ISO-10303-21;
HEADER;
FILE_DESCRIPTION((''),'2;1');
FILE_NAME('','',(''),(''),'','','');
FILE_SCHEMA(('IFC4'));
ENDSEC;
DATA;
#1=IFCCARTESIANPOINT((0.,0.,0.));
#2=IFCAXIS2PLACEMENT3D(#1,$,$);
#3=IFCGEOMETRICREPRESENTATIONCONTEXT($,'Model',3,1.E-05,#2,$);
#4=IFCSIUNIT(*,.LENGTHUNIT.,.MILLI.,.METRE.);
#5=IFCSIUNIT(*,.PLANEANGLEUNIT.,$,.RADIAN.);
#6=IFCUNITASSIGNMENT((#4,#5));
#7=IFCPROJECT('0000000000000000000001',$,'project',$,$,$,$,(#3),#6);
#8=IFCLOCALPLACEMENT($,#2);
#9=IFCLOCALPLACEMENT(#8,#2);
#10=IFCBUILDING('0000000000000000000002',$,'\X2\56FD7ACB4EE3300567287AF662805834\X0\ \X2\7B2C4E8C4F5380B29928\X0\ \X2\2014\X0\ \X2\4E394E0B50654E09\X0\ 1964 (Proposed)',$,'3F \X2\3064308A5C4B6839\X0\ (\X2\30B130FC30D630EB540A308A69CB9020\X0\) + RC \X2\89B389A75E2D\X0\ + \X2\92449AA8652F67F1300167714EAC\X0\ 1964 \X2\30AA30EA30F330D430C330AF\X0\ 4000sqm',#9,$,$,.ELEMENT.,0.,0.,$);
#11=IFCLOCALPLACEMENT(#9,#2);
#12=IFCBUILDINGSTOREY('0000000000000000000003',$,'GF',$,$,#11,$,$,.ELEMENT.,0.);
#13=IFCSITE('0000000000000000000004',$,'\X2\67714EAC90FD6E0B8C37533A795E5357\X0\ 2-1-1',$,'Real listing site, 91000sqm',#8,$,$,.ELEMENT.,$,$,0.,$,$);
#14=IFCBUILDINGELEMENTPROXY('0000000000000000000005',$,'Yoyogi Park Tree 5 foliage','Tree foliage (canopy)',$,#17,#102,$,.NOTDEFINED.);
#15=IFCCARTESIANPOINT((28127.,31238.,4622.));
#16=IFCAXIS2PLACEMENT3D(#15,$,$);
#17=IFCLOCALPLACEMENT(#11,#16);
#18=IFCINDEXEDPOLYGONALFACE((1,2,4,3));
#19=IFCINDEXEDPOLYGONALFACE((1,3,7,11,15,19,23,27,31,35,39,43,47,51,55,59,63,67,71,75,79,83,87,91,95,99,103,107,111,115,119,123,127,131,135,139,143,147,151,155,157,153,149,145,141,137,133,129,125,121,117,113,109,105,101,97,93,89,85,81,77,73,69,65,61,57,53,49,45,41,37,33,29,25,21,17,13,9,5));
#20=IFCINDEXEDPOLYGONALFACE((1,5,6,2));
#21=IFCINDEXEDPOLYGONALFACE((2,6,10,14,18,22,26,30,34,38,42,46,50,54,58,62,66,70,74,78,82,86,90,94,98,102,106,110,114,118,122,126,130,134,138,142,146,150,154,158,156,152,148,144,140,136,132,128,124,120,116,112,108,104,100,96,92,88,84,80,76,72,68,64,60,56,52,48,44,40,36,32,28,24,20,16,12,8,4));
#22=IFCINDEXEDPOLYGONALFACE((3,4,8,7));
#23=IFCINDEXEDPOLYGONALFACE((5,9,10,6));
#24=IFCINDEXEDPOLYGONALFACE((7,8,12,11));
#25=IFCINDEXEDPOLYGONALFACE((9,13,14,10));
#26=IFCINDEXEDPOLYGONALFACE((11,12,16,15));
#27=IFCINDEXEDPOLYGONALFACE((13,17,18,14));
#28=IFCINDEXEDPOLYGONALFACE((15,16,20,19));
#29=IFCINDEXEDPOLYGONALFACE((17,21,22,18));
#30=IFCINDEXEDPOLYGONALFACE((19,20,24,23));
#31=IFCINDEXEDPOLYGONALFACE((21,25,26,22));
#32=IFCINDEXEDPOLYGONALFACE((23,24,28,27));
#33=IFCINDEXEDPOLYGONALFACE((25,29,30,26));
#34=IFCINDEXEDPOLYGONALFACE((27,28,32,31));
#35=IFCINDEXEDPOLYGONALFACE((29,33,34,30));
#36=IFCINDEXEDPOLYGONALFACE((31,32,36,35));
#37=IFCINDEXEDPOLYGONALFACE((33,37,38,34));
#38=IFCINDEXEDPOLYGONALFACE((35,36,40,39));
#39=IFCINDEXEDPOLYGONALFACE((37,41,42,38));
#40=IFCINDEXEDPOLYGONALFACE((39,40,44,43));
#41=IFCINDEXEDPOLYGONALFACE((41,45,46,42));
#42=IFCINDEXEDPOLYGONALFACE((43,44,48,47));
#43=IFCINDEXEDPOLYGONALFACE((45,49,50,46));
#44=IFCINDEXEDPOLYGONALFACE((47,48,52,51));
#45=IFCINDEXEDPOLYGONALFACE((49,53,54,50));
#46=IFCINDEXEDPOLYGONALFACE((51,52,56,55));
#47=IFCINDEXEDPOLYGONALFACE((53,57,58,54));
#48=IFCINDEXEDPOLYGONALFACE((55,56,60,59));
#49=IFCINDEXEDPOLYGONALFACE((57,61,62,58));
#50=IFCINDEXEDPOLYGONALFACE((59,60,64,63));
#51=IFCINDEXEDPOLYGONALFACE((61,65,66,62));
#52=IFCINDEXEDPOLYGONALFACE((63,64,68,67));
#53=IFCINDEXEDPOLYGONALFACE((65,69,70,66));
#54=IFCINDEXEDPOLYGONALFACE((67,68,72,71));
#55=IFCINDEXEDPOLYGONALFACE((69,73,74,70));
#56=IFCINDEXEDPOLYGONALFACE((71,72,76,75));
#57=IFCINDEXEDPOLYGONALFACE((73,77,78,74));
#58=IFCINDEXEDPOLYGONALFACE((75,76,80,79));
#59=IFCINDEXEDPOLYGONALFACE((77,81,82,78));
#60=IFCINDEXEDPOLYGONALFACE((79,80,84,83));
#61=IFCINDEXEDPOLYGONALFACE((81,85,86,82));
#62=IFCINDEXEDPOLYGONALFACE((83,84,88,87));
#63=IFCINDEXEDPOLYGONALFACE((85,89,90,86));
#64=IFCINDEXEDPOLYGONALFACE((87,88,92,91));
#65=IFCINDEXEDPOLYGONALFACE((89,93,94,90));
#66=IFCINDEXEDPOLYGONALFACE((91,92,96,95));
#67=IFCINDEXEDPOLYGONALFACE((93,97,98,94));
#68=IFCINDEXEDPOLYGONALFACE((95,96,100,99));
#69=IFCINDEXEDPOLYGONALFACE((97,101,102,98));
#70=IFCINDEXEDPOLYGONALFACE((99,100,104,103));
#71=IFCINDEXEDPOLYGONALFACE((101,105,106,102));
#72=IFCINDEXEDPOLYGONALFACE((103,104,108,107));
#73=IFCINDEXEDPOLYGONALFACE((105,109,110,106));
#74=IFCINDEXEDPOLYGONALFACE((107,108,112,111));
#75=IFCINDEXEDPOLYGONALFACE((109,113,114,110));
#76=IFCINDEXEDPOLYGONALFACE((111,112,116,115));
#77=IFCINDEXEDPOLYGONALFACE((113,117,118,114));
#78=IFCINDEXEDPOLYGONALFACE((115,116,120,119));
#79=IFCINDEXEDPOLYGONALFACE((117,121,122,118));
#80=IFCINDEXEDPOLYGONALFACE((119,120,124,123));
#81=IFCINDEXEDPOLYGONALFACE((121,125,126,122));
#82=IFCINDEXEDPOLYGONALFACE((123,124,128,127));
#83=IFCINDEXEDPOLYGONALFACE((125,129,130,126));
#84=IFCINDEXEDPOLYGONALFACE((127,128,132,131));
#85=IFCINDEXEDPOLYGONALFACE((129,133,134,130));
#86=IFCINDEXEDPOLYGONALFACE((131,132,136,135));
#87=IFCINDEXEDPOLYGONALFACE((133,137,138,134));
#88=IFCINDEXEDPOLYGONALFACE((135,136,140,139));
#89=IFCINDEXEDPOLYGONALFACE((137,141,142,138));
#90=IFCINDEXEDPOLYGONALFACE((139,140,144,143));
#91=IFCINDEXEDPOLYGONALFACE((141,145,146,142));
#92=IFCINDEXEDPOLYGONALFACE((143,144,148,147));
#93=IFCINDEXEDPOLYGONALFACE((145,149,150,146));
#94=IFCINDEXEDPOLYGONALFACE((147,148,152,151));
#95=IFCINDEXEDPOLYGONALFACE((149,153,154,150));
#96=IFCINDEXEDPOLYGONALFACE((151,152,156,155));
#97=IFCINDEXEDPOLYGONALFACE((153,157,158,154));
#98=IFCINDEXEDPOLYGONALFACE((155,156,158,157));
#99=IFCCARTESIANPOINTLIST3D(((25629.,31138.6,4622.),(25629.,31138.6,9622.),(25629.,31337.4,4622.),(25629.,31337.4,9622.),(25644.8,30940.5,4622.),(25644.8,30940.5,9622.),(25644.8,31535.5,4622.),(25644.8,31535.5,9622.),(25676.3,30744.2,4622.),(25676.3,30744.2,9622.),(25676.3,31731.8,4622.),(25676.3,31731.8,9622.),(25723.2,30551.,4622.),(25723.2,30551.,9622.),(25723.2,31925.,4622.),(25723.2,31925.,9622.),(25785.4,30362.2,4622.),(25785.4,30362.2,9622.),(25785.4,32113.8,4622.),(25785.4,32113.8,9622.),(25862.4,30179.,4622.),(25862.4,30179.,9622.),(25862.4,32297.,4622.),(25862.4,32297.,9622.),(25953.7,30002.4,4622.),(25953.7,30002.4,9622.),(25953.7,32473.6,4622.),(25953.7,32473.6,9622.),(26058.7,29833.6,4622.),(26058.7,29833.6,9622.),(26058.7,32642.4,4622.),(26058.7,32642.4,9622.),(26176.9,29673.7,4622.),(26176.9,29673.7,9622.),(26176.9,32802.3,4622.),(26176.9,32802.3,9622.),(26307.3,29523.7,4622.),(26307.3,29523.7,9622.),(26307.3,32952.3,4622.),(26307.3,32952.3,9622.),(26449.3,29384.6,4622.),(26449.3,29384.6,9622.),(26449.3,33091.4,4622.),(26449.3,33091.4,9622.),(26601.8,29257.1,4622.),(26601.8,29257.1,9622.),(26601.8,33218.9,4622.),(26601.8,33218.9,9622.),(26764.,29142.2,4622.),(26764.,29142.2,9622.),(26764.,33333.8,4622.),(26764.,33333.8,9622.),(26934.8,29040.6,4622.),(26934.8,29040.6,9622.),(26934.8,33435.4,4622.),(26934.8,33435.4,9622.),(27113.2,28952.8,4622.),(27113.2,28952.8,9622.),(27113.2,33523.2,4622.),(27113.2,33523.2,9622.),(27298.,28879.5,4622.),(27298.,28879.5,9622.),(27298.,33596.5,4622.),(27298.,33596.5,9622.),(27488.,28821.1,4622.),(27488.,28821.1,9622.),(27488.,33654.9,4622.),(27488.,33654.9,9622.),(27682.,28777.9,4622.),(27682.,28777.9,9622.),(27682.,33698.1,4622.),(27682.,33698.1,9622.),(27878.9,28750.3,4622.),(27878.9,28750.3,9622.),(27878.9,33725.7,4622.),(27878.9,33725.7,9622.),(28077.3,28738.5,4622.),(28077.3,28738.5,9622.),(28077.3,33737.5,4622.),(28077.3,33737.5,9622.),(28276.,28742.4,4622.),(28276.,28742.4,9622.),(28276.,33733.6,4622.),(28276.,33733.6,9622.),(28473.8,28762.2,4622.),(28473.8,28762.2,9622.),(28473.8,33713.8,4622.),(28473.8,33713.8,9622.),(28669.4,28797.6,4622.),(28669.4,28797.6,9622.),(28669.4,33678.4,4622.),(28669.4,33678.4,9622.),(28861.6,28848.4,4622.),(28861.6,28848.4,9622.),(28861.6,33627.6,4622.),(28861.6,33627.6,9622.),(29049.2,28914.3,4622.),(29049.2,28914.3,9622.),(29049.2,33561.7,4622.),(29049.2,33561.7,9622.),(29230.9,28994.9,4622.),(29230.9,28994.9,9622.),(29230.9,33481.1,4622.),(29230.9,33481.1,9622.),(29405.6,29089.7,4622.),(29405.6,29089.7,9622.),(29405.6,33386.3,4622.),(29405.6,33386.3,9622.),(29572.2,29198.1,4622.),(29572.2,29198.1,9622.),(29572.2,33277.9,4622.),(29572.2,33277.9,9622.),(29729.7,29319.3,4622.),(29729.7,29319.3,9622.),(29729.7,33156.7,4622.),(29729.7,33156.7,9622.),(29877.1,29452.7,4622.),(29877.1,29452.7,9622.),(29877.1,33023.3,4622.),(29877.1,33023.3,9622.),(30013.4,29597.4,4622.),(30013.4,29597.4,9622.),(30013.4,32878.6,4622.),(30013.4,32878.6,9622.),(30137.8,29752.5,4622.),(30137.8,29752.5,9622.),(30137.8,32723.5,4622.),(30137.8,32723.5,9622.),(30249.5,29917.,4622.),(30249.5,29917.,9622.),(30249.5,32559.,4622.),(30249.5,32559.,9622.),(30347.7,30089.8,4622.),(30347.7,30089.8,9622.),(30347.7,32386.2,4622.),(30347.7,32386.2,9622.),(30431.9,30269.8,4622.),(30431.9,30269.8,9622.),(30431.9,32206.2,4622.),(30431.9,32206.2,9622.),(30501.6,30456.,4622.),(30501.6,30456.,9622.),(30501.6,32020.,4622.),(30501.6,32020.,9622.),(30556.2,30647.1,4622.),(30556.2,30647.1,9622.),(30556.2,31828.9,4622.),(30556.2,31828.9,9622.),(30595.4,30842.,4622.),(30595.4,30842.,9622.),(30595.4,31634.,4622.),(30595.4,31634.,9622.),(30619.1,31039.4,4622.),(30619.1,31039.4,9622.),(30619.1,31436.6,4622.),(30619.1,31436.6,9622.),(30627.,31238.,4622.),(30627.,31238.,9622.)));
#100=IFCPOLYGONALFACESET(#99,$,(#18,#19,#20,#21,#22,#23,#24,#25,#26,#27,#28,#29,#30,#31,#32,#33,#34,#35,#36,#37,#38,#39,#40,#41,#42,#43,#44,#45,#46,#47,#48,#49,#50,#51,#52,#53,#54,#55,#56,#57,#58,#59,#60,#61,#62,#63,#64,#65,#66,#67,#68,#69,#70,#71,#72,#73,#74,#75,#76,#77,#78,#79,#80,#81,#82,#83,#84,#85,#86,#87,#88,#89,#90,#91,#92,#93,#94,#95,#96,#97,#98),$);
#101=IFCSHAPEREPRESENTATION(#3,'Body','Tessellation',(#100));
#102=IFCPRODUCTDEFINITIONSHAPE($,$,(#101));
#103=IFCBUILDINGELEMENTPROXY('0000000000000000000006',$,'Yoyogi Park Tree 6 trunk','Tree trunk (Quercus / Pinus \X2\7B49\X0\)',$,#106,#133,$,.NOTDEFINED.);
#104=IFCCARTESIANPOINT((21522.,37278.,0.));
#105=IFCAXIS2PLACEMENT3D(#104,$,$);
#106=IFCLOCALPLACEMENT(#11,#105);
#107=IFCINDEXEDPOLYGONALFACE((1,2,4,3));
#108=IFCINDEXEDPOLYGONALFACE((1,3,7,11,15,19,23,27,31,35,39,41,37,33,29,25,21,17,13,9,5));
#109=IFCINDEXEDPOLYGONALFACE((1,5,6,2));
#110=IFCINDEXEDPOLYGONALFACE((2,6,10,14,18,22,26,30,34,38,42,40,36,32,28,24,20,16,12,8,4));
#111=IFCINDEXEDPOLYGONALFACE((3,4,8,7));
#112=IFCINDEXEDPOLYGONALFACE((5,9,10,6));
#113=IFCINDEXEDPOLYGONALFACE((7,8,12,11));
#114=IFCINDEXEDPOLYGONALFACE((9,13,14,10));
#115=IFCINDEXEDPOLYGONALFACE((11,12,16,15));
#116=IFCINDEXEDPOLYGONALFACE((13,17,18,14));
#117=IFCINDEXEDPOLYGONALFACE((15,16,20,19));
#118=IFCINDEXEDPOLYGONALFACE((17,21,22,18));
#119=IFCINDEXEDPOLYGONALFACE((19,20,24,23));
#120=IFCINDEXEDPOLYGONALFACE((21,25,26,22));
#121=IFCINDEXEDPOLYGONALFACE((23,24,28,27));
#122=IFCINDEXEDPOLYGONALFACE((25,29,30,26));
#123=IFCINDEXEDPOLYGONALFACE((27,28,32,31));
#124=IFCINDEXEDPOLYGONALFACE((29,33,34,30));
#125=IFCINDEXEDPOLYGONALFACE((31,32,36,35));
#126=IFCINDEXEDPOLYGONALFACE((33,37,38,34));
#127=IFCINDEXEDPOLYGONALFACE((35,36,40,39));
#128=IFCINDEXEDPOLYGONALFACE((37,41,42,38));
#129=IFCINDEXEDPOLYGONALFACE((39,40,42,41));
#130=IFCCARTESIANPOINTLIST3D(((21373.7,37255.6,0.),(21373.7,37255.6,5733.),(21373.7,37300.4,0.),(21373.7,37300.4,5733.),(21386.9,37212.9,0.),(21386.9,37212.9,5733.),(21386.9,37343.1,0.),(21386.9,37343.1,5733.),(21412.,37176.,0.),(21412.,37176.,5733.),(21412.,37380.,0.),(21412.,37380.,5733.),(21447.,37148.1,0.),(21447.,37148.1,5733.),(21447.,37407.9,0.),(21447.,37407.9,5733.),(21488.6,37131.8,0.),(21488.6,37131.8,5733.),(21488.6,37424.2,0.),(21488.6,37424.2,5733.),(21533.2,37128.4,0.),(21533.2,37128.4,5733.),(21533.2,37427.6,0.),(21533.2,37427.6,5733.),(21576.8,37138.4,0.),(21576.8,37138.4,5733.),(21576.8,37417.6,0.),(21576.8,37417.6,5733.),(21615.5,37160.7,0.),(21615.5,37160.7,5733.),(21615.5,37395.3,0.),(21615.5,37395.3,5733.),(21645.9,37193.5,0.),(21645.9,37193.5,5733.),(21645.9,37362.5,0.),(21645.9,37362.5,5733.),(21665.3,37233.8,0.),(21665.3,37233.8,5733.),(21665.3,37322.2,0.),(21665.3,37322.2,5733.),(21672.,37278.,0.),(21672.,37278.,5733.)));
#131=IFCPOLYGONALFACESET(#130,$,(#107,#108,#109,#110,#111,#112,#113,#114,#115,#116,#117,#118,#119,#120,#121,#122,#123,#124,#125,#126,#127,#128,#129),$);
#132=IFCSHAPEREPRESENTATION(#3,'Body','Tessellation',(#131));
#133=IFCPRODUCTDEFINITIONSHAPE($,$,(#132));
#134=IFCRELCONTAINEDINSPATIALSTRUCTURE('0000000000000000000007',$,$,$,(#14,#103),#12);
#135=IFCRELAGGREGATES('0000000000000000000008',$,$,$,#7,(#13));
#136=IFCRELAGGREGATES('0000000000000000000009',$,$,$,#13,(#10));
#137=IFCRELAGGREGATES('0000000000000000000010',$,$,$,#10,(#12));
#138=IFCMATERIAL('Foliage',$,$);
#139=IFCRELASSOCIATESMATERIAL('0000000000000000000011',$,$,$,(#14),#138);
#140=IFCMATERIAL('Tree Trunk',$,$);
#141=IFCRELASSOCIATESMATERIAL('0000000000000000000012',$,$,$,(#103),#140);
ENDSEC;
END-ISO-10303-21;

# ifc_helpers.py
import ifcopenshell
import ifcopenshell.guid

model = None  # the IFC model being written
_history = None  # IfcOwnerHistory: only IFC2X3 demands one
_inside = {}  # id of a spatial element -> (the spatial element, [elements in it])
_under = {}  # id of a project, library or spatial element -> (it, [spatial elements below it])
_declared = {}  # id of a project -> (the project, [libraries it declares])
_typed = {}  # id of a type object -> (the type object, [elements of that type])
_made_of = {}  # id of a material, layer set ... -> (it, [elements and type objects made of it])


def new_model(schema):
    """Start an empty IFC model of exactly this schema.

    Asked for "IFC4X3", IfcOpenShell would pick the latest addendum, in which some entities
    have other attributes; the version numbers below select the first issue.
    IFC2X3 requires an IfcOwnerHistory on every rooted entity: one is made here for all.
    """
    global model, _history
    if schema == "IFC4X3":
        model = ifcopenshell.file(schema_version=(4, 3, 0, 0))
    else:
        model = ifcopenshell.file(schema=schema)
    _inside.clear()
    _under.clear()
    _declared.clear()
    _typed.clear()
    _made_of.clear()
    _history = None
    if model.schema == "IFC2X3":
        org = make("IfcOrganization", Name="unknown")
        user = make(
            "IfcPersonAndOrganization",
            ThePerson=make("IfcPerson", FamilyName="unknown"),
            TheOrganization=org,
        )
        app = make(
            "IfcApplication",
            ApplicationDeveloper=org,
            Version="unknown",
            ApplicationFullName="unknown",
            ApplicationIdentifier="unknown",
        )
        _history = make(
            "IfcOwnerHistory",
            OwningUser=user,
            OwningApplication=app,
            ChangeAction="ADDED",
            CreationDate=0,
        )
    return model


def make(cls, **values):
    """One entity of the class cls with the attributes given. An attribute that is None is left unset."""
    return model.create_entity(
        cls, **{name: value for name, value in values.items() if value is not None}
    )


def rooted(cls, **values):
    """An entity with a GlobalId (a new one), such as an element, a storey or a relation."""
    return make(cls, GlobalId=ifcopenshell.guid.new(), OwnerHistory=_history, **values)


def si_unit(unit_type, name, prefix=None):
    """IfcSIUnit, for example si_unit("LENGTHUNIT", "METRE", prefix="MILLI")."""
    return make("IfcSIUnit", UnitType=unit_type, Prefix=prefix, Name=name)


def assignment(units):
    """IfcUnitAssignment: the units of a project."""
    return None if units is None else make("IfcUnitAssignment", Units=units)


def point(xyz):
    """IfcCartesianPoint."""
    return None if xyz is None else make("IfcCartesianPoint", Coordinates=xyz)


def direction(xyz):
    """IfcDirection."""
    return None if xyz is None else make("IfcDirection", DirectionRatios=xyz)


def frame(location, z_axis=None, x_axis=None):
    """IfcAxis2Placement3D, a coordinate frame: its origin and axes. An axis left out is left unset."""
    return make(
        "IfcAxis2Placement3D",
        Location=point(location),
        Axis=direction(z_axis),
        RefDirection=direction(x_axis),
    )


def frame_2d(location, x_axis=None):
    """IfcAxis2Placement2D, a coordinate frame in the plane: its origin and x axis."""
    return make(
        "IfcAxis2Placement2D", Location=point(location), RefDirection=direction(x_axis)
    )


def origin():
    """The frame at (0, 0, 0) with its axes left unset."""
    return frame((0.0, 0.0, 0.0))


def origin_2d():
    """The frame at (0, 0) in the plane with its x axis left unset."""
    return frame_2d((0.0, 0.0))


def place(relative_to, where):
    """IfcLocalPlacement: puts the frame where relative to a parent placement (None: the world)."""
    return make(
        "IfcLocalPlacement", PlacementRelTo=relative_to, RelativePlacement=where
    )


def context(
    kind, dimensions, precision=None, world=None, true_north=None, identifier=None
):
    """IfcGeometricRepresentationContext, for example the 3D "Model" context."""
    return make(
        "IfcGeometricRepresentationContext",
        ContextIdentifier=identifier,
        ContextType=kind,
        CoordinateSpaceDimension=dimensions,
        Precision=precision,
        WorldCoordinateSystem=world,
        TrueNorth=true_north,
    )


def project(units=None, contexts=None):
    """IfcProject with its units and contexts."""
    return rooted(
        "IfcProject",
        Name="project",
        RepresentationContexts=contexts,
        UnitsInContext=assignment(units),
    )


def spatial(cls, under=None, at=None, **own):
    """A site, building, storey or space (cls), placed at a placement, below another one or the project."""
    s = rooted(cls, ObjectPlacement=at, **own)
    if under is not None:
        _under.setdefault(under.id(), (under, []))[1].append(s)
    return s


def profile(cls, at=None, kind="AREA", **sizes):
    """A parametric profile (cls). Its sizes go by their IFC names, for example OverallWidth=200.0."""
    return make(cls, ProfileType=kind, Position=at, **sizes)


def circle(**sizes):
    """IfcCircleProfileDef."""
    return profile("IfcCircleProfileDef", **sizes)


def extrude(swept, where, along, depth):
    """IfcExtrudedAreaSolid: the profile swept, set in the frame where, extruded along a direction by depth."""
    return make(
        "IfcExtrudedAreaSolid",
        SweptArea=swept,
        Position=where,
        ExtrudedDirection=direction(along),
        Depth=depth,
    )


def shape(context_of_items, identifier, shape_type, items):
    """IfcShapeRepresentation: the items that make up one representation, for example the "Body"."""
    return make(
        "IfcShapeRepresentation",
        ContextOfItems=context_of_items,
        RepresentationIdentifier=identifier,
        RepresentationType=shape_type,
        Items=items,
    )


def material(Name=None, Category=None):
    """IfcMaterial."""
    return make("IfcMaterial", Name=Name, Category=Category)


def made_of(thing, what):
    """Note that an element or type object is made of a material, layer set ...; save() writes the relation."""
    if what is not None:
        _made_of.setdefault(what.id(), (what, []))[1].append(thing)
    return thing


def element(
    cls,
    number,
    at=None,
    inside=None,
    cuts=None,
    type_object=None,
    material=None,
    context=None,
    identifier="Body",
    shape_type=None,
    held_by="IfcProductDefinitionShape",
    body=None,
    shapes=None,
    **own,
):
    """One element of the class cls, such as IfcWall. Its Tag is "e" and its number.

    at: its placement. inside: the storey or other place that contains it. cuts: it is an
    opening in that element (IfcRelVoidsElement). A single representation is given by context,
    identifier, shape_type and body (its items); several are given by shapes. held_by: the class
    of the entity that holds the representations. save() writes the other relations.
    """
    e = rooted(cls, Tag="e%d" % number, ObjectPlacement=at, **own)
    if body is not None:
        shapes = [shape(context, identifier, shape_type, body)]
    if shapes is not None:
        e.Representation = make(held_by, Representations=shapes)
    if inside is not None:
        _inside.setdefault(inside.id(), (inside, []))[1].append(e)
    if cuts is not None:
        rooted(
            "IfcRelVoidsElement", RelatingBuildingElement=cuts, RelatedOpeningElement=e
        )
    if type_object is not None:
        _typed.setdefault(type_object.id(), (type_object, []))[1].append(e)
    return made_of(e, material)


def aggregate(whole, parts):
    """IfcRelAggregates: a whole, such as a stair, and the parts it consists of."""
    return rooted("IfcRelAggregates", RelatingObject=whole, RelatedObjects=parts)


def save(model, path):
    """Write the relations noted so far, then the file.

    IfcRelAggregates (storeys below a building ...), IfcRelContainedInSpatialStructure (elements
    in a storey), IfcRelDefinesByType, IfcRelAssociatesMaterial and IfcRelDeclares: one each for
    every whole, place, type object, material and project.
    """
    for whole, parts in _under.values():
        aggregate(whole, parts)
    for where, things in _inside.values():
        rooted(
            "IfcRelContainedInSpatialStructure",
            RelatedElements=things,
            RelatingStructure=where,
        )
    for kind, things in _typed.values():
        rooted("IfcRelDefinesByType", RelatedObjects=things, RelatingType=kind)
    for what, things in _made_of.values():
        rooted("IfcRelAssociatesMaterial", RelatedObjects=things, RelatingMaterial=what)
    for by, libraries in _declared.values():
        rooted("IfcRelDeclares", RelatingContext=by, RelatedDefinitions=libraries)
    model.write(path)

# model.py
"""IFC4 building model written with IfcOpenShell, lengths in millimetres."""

from ifc_helpers import new_model, si_unit, frame, origin, origin_2d, place, context, project, spatial, circle, extrude, material, element, save


model = new_model("IFC4")

# Units and contexts
model_context = context("Model", 3, precision=1e-05, world=origin())
ifc_project = project(units=[si_unit("LENGTHUNIT", "METRE", prefix="MILLI"), si_unit("PLANEANGLEUNIT", "RADIAN")], contexts=[model_context])

# Site, building, storey
site_placement = place(None, origin())
site = spatial("IfcSite", under=ifc_project, at=site_placement, Name="東京都渋谷区神南 2-1-1", ObjectType="Real listing site, 91000sqm", CompositionType="ELEMENT", RefElevation=0.0)
building_placement = place(site_placement, origin())
building = spatial("IfcBuilding", under=site, at=building_placement, Name="国立代々木競技場 第二体育館 — 丹下健三 1964 (Proposed)", ObjectType="3F つり屋根 (ケーブル吊り構造) + RC 観覧席 + 鉄骨支柱、東京 1964 オリンピック 4000sqm", CompositionType="ELEMENT", ElevationOfRefHeight=0.0, ElevationOfTerrain=0.0)
storey_placement = place(building_placement, origin())
storey = spatial("IfcBuildingStorey", under=building, at=storey_placement, Name="GF", CompositionType="ELEMENT", Elevation=0.0)

# Building element proxies
ifc_material_1 = material(Name="Tree Trunk")
ifc_material_2 = material(Name="Foliage")
proxy_1_placement = place(storey_placement, frame((28127.0, 31238.0, 4622.0)))
element("IfcBuildingElementProxy", 1, at=proxy_1_placement, inside=storey, material=ifc_material_2, Name="Yoyogi Park Tree 5 foliage", Description="Tree foliage (canopy)", PredefinedType="NOTDEFINED", context=model_context, shape_type="SweptSolid", body=[
    extrude(circle(Radius=2500.0, at=origin_2d()), frame((28127.0, 31238.0, 4622.0)), (0.0, 0.0, 1.0), 5000.0),
])
proxy_2_placement = place(storey_placement, frame((21522.0, 37278.0, 0.0)))
element("IfcBuildingElementProxy", 2, at=proxy_2_placement, inside=storey, material=ifc_material_1, Name="Yoyogi Park Tree 6 trunk", Description="Tree trunk (Quercus / Pinus 等)", PredefinedType="NOTDEFINED", context=model_context, shape_type="SweptSolid", body=[
    extrude(circle(Radius=150.0, at=origin_2d()), frame((21522.0, 37278.0, 0.0)), (0.0, 0.0, 1.0), 5733.0),
])

save(model, "model.ifc")
